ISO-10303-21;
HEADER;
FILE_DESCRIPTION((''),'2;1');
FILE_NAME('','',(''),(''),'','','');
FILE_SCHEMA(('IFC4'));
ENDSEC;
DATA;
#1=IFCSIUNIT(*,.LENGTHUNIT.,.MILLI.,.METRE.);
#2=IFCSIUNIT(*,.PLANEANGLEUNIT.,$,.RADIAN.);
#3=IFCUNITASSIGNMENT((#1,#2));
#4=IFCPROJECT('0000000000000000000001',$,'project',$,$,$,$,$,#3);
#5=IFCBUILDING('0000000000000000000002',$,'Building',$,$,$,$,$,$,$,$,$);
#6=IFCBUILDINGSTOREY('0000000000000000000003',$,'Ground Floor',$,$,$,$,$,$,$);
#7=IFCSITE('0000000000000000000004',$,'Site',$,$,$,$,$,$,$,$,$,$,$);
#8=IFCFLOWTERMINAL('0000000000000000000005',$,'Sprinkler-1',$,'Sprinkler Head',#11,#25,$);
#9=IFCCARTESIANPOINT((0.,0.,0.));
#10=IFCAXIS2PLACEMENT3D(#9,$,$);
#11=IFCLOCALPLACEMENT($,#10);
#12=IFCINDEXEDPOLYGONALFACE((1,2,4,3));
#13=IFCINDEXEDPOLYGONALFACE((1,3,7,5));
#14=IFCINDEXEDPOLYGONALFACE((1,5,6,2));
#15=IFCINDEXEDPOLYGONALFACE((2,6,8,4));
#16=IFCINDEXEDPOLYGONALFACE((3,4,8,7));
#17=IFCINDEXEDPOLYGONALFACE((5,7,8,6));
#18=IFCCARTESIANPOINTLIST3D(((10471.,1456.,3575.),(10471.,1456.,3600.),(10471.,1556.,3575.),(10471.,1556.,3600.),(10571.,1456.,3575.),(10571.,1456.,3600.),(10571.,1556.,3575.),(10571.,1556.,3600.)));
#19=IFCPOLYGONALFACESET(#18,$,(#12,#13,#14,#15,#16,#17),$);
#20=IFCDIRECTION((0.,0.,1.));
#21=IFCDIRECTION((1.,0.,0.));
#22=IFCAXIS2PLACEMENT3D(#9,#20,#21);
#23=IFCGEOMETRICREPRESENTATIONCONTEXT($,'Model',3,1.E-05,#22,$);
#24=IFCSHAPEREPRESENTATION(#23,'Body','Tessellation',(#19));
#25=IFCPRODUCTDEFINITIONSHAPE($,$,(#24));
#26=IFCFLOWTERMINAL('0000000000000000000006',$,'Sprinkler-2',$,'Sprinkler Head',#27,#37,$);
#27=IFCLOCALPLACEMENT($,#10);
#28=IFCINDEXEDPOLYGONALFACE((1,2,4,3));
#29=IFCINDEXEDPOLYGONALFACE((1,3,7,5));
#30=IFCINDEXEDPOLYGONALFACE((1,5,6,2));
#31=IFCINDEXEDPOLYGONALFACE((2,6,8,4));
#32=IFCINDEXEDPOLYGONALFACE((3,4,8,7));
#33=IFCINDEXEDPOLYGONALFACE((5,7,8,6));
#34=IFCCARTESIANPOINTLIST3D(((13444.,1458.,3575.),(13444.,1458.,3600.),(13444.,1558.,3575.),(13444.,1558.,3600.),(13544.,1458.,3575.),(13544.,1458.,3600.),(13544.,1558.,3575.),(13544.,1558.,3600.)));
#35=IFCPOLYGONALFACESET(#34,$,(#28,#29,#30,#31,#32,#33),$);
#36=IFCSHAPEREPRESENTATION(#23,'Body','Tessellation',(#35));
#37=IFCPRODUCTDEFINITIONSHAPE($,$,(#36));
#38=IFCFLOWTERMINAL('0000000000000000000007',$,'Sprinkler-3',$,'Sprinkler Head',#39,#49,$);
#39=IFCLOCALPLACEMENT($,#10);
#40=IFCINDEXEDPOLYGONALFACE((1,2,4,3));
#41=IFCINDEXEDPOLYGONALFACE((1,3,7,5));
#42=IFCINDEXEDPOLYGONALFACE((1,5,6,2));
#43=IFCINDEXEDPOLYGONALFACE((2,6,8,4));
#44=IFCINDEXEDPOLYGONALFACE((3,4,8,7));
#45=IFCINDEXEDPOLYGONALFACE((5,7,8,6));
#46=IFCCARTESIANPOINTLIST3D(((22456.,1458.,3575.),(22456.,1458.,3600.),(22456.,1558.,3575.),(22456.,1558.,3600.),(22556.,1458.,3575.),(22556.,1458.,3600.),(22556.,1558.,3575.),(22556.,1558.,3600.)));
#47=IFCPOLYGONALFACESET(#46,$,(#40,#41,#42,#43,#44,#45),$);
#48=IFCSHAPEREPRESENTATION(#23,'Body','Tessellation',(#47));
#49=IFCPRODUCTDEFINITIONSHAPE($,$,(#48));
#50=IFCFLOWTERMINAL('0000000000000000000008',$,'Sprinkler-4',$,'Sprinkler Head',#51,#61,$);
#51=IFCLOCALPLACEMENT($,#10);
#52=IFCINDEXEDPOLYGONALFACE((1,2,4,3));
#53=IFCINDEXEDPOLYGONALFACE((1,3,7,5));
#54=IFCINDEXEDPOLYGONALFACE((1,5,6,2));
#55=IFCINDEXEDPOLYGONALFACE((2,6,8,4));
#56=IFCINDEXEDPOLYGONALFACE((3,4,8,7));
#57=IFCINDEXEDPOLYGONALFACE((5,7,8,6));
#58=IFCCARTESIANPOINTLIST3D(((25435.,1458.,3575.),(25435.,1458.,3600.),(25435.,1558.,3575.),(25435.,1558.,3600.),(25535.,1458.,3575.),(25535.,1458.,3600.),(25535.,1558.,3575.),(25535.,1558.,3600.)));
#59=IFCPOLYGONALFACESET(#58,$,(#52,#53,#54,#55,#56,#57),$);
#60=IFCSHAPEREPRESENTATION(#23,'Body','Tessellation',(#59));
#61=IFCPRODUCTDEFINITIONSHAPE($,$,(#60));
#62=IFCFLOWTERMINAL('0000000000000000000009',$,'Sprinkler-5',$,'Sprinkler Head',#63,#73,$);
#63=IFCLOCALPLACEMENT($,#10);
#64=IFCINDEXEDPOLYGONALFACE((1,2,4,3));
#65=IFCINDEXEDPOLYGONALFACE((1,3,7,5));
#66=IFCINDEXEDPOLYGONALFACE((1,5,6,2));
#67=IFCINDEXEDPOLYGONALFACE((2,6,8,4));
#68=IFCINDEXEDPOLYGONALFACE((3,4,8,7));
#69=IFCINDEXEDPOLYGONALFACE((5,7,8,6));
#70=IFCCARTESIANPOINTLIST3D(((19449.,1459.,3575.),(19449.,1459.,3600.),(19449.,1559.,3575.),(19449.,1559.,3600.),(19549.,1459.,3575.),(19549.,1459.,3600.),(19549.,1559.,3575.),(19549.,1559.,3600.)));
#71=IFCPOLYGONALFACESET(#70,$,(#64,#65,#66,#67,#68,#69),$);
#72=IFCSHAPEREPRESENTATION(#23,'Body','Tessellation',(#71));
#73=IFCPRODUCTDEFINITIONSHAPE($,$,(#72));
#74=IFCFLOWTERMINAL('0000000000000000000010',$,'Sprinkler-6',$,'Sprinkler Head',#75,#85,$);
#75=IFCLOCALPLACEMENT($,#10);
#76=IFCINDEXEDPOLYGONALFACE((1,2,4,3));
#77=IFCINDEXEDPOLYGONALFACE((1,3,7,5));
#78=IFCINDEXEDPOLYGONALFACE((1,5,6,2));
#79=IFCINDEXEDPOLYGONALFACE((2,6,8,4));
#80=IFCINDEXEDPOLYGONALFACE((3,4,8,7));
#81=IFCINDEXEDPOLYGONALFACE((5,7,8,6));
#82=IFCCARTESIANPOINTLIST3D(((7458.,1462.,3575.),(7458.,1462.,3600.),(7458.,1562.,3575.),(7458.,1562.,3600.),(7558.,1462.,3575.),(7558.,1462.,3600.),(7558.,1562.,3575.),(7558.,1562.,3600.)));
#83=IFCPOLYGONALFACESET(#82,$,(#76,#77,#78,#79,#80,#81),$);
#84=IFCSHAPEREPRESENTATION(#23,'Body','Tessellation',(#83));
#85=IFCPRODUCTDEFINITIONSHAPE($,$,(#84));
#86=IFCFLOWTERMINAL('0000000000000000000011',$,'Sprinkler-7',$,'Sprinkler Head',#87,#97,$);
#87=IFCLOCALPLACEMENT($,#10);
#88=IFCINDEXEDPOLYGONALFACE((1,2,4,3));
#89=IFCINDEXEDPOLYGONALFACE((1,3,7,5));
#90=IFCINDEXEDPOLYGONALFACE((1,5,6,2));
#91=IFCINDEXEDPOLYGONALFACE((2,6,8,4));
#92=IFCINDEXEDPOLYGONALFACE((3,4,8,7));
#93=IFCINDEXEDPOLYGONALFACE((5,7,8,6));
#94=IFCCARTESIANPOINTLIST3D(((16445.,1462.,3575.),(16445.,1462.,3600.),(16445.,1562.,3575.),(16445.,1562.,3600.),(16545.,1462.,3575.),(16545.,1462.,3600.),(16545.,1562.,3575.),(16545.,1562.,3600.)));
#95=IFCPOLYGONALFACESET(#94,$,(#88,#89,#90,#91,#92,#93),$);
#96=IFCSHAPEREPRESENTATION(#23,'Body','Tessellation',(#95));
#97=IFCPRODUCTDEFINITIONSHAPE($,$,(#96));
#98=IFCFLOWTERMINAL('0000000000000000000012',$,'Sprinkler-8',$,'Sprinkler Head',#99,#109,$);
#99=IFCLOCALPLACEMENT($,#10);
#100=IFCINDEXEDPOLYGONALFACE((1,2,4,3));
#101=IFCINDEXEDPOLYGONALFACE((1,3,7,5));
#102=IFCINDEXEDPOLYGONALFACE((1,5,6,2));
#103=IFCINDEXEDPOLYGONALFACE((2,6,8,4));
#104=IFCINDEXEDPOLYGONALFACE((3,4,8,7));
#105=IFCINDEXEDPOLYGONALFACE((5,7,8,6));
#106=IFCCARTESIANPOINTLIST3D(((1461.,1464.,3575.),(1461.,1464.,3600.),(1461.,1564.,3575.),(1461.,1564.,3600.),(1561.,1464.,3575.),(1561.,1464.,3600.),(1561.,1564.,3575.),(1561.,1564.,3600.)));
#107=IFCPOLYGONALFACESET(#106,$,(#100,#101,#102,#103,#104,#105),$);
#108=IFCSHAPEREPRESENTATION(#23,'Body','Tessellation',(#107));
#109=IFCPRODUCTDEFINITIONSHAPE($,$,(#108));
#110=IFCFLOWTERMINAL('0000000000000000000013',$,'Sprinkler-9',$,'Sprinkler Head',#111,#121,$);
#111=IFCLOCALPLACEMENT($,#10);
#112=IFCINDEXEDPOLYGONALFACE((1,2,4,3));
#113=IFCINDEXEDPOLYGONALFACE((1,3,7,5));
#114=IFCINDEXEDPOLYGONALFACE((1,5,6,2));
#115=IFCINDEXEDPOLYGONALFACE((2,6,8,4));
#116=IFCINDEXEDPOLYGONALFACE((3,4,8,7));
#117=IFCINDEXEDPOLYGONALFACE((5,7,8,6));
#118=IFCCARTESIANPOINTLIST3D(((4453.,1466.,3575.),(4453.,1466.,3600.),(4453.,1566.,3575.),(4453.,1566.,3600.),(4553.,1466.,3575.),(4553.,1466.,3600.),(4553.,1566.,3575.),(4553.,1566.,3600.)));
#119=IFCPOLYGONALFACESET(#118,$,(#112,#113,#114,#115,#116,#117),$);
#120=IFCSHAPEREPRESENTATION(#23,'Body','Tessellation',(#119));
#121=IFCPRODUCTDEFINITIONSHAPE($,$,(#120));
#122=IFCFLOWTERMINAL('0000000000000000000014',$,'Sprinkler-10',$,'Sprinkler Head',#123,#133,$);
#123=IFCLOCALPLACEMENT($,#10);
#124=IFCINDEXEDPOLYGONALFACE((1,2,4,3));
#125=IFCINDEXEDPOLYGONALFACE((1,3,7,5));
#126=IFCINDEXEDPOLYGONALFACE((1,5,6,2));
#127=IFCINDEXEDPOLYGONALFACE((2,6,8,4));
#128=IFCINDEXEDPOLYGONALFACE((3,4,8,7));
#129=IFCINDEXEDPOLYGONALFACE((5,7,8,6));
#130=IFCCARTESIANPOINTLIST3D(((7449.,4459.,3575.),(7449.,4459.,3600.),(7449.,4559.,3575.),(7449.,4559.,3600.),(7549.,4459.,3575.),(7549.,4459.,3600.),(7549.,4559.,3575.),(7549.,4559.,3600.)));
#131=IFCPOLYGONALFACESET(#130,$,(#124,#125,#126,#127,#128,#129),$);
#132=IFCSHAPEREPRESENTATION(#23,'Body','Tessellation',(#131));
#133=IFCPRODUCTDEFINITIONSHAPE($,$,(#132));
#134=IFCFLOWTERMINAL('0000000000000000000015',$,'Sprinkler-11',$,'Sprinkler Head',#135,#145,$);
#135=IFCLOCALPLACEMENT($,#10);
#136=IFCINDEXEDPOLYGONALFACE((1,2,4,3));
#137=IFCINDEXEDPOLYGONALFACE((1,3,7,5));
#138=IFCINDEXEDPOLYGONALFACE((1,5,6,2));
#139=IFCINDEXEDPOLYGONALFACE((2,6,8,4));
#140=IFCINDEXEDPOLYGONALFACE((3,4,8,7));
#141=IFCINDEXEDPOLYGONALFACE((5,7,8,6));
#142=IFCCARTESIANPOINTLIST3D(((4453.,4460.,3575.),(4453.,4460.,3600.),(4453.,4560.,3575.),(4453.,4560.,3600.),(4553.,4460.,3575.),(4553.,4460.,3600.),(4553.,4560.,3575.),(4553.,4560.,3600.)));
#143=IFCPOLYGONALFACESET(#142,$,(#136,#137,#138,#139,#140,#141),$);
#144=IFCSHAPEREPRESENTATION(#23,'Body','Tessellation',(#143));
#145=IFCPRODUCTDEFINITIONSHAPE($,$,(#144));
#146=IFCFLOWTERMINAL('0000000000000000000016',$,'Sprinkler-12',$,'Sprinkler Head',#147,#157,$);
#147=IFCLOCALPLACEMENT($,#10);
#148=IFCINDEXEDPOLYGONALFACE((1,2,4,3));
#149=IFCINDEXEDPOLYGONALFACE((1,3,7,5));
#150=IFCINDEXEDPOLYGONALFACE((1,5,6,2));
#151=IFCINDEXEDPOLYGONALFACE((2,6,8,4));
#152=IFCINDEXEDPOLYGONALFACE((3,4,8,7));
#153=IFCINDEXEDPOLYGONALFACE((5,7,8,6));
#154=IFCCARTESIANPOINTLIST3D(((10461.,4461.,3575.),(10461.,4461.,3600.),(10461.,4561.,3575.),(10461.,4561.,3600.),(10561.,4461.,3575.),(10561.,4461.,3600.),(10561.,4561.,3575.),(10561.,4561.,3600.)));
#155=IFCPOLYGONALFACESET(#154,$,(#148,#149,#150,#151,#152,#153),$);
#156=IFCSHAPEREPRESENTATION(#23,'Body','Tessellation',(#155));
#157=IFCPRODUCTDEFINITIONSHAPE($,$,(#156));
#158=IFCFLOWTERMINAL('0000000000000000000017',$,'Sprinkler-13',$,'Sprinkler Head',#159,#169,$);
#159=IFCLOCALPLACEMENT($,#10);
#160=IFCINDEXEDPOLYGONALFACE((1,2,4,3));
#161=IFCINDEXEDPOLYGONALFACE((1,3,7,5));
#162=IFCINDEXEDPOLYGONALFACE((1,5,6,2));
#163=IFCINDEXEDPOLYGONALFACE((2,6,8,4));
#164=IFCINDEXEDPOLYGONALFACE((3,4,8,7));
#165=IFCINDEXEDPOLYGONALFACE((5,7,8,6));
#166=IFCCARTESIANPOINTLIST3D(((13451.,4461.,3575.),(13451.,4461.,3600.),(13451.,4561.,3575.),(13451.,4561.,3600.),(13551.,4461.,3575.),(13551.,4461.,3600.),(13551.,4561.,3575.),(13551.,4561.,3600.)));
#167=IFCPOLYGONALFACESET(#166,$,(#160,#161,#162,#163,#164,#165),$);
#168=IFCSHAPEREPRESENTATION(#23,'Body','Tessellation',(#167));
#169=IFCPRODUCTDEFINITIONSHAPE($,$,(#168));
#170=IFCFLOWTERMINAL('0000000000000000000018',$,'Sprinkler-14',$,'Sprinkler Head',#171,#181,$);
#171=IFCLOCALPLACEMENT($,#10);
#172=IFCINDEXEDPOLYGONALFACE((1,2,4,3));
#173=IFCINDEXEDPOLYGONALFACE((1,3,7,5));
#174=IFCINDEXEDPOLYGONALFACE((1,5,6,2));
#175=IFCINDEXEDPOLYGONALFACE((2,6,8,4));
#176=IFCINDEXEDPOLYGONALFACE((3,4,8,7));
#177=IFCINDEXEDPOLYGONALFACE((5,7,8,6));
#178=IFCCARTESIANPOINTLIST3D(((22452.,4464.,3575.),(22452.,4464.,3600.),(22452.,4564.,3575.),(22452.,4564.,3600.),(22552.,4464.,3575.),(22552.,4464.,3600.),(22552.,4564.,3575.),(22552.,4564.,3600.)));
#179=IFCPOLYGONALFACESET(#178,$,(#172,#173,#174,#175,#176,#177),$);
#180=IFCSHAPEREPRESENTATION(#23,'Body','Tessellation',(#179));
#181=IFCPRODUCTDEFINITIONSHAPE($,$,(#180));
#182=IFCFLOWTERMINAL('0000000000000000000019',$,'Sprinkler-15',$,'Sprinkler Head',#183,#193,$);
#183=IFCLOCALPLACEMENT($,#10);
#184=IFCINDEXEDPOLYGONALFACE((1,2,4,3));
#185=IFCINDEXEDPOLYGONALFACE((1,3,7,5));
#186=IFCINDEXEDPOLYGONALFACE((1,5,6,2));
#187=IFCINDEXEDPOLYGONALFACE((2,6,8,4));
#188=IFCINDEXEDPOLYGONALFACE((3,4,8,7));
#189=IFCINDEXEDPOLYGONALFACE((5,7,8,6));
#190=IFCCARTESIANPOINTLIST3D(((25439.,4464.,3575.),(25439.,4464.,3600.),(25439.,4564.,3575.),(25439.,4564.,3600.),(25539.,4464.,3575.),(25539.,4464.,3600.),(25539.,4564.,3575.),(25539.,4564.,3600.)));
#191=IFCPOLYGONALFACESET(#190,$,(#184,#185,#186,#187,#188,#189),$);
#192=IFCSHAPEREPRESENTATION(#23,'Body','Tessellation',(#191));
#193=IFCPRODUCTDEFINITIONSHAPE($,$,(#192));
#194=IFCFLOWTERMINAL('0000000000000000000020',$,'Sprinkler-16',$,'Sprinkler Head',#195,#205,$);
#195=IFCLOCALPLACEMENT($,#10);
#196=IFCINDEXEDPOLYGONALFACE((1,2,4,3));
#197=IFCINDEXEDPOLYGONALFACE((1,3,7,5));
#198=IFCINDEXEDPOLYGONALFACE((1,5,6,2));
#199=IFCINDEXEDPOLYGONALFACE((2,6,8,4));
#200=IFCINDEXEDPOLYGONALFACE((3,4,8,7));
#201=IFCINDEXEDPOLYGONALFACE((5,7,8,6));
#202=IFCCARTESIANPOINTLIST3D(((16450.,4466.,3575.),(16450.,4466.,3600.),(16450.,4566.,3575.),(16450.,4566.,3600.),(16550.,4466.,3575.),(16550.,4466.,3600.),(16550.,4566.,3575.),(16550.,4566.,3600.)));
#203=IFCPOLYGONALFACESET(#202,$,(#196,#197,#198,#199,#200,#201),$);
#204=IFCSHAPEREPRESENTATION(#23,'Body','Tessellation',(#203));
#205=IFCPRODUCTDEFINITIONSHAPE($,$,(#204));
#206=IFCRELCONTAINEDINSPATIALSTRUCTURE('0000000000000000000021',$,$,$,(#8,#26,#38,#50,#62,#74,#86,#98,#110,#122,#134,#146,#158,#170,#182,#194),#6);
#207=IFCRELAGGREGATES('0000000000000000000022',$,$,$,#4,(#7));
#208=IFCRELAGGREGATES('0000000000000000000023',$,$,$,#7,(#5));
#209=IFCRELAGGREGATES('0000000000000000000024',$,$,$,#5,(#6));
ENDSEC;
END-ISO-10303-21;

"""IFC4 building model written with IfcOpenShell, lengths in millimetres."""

from ifc_helpers import new_model, si_unit, frame, origin_with_axes, place, context, project, spatial, rectangle, extrude, element, save


model = new_model("IFC4")

# Units and contexts
model_context = context("Model", 3, precision=1e-05, world=origin_with_axes())
ifc_project = project(units=[si_unit("LENGTHUNIT", "METRE", prefix="MILLI"), si_unit("PLANEANGLEUNIT", "RADIAN")])

# Site, building, storey
site = spatial("IfcSite", under=ifc_project, Name="Site")
building = spatial("IfcBuilding", under=site, Name="Building")
storey = spatial("IfcBuildingStorey", under=building, Name="Ground Floor")

# Flow terminals
flow_terminal_1_placement = place(None, origin_with_axes())
element("IfcFlowTerminal", 1, at=flow_terminal_1_placement, inside=storey, Name="Sprinkler-1", ObjectType="Sprinkler Head", context=model_context, shape_type="SweptSolid", body=[
    extrude(rectangle(XDim=100.0, YDim=100.0), frame((10521.0, 1506.0, 3575.0), z_axis=(0.0, 0.0, 1.0), x_axis=(1.0, 0.0, 0.0)), (0.0, 0.0, 1.0), 25.0),
])
flow_terminal_2_placement = place(None, origin_with_axes())
element("IfcFlowTerminal", 2, at=flow_terminal_2_placement, inside=storey, Name="Sprinkler-2", ObjectType="Sprinkler Head", context=model_context, shape_type="SweptSolid", body=[
    extrude(rectangle(XDim=100.0, YDim=100.0), frame((13494.0, 1508.0, 3575.0), z_axis=(0.0, 0.0, 1.0), x_axis=(1.0, 0.0, 0.0)), (0.0, 0.0, 1.0), 25.0),
])
flow_terminal_3_placement = place(None, origin_with_axes())
element("IfcFlowTerminal", 3, at=flow_terminal_3_placement, inside=storey, Name="Sprinkler-3", ObjectType="Sprinkler Head", context=model_context, shape_type="SweptSolid", body=[
    extrude(rectangle(XDim=100.0, YDim=100.0), frame((22506.0, 1508.0, 3575.0), z_axis=(0.0, 0.0, 1.0), x_axis=(1.0, 0.0, 0.0)), (0.0, 0.0, 1.0), 25.0),
])
flow_terminal_4_placement = place(None, origin_with_axes())
element("IfcFlowTerminal", 4, at=flow_terminal_4_placement, inside=storey, Name="Sprinkler-4", ObjectType="Sprinkler Head", context=model_context, shape_type="SweptSolid", body=[
    extrude(rectangle(XDim=100.0, YDim=100.0), frame((25485.0, 1508.0, 3575.0), z_axis=(0.0, 0.0, 1.0), x_axis=(1.0, 0.0, 0.0)), (0.0, 0.0, 1.0), 25.0),
])
flow_terminal_5_placement = place(None, origin_with_axes())
element("IfcFlowTerminal", 5, at=flow_terminal_5_placement, inside=storey, Name="Sprinkler-5", ObjectType="Sprinkler Head", context=model_context, shape_type="SweptSolid", body=[
    extrude(rectangle(XDim=100.0, YDim=100.0), frame((19499.0, 1509.0, 3575.0), z_axis=(0.0, 0.0, 1.0), x_axis=(1.0, 0.0, 0.0)), (0.0, 0.0, 1.0), 25.0),
])
flow_terminal_6_placement = place(None, origin_with_axes())
element("IfcFlowTerminal", 6, at=flow_terminal_6_placement, inside=storey, Name="Sprinkler-6", ObjectType="Sprinkler Head", context=model_context, shape_type="SweptSolid", body=[
    extrude(rectangle(XDim=100.0, YDim=100.0), frame((7508.0, 1512.0, 3575.0), z_axis=(0.0, 0.0, 1.0), x_axis=(1.0, 0.0, 0.0)), (0.0, 0.0, 1.0), 25.0),
])
flow_terminal_7_placement = place(None, origin_with_axes())
element("IfcFlowTerminal", 7, at=flow_terminal_7_placement, inside=storey, Name="Sprinkler-7", ObjectType="Sprinkler Head", context=model_context, shape_type="SweptSolid", body=[
    extrude(rectangle(XDim=100.0, YDim=100.0), frame((16495.0, 1512.0, 3575.0), z_axis=(0.0, 0.0, 1.0), x_axis=(1.0, 0.0, 0.0)), (0.0, 0.0, 1.0), 25.0),
])
flow_terminal_8_placement = place(None, origin_with_axes())
element("IfcFlowTerminal", 8, at=flow_terminal_8_placement, inside=storey, Name="Sprinkler-8", ObjectType="Sprinkler Head", context=model_context, shape_type="SweptSolid", body=[
    extrude(rectangle(XDim=100.0, YDim=100.0), frame((1511.0, 1514.0, 3575.0), z_axis=(0.0, 0.0, 1.0), x_axis=(1.0, 0.0, 0.0)), (0.0, 0.0, 1.0), 25.0),
])
flow_terminal_9_placement = place(None, origin_with_axes())
element("IfcFlowTerminal", 9, at=flow_terminal_9_placement, inside=storey, Name="Sprinkler-9", ObjectType="Sprinkler Head", context=model_context, shape_type="SweptSolid", body=[
    extrude(rectangle(XDim=100.0, YDim=100.0), frame((4503.0, 1516.0, 3575.0), z_axis=(0.0, 0.0, 1.0), x_axis=(1.0, 0.0, 0.0)), (0.0, 0.0, 1.0), 25.0),
])
flow_terminal_10_placement = place(None, origin_with_axes())
element("IfcFlowTerminal", 10, at=flow_terminal_10_placement, inside=storey, Name="Sprinkler-10", ObjectType="Sprinkler Head", context=model_context, shape_type="SweptSolid", body=[
    extrude(rectangle(XDim=100.0, YDim=100.0), frame((7499.0, 4509.0, 3575.0), z_axis=(0.0, 0.0, 1.0), x_axis=(1.0, 0.0, 0.0)), (0.0, 0.0, 1.0), 25.0),
])
flow_terminal_11_placement = place(None, origin_with_axes())
element("IfcFlowTerminal", 11, at=flow_terminal_11_placement, inside=storey, Name="Sprinkler-11", ObjectType="Sprinkler Head", context=model_context, shape_type="SweptSolid", body=[
    extrude(rectangle(XDim=100.0, YDim=100.0), frame((4503.0, 4510.0, 3575.0), z_axis=(0.0, 0.0, 1.0), x_axis=(1.0, 0.0, 0.0)), (0.0, 0.0, 1.0), 25.0),
])
flow_terminal_12_placement = place(None, origin_with_axes())
element("IfcFlowTerminal", 12, at=flow_terminal_12_placement, inside=storey, Name="Sprinkler-12", ObjectType="Sprinkler Head", context=model_context, shape_type="SweptSolid", body=[
    extrude(rectangle(XDim=100.0, YDim=100.0), frame((10511.0, 4511.0, 3575.0), z_axis=(0.0, 0.0, 1.0), x_axis=(1.0, 0.0, 0.0)), (0.0, 0.0, 1.0), 25.0),
])
flow_terminal_13_placement = place(None, origin_with_axes())
element("IfcFlowTerminal", 13, at=flow_terminal_13_placement, inside=storey, Name="Sprinkler-13", ObjectType="Sprinkler Head", context=model_context, shape_type="SweptSolid", body=[
    extrude(rectangle(XDim=100.0, YDim=100.0), frame((13501.0, 4511.0, 3575.0), z_axis=(0.0, 0.0, 1.0), x_axis=(1.0, 0.0, 0.0)), (0.0, 0.0, 1.0), 25.0),
])
flow_terminal_14_placement = place(None, origin_with_axes())
element("IfcFlowTerminal", 14, at=flow_terminal_14_placement, inside=storey, Name="Sprinkler-14", ObjectType="Sprinkler Head", context=model_context, shape_type="SweptSolid", body=[
    extrude(rectangle(XDim=100.0, YDim=100.0), frame((22502.0, 4514.0, 3575.0), z_axis=(0.0, 0.0, 1.0), x_axis=(1.0, 0.0, 0.0)), (0.0, 0.0, 1.0), 25.0),
])
flow_terminal_15_placement = place(None, origin_with_axes())
element("IfcFlowTerminal", 15, at=flow_terminal_15_placement, inside=storey, Name="Sprinkler-15", ObjectType="Sprinkler Head", context=model_context, shape_type="SweptSolid", body=[
    extrude(rectangle(XDim=100.0, YDim=100.0), frame((25489.0, 4514.0, 3575.0), z_axis=(0.0, 0.0, 1.0), x_axis=(1.0, 0.0, 0.0)), (0.0, 0.0, 1.0), 25.0),
])
flow_terminal_16_placement = place(None, origin_with_axes())
element("IfcFlowTerminal", 16, at=flow_terminal_16_placement, inside=storey, Name="Sprinkler-16", ObjectType="Sprinkler Head", context=model_context, shape_type="SweptSolid", body=[
    extrude(rectangle(XDim=100.0, YDim=100.0), frame((16500.0, 4516.0, 3575.0), z_axis=(0.0, 0.0, 1.0), x_axis=(1.0, 0.0, 0.0)), (0.0, 0.0, 1.0), 25.0),
])

save(model, "model.ifc")
